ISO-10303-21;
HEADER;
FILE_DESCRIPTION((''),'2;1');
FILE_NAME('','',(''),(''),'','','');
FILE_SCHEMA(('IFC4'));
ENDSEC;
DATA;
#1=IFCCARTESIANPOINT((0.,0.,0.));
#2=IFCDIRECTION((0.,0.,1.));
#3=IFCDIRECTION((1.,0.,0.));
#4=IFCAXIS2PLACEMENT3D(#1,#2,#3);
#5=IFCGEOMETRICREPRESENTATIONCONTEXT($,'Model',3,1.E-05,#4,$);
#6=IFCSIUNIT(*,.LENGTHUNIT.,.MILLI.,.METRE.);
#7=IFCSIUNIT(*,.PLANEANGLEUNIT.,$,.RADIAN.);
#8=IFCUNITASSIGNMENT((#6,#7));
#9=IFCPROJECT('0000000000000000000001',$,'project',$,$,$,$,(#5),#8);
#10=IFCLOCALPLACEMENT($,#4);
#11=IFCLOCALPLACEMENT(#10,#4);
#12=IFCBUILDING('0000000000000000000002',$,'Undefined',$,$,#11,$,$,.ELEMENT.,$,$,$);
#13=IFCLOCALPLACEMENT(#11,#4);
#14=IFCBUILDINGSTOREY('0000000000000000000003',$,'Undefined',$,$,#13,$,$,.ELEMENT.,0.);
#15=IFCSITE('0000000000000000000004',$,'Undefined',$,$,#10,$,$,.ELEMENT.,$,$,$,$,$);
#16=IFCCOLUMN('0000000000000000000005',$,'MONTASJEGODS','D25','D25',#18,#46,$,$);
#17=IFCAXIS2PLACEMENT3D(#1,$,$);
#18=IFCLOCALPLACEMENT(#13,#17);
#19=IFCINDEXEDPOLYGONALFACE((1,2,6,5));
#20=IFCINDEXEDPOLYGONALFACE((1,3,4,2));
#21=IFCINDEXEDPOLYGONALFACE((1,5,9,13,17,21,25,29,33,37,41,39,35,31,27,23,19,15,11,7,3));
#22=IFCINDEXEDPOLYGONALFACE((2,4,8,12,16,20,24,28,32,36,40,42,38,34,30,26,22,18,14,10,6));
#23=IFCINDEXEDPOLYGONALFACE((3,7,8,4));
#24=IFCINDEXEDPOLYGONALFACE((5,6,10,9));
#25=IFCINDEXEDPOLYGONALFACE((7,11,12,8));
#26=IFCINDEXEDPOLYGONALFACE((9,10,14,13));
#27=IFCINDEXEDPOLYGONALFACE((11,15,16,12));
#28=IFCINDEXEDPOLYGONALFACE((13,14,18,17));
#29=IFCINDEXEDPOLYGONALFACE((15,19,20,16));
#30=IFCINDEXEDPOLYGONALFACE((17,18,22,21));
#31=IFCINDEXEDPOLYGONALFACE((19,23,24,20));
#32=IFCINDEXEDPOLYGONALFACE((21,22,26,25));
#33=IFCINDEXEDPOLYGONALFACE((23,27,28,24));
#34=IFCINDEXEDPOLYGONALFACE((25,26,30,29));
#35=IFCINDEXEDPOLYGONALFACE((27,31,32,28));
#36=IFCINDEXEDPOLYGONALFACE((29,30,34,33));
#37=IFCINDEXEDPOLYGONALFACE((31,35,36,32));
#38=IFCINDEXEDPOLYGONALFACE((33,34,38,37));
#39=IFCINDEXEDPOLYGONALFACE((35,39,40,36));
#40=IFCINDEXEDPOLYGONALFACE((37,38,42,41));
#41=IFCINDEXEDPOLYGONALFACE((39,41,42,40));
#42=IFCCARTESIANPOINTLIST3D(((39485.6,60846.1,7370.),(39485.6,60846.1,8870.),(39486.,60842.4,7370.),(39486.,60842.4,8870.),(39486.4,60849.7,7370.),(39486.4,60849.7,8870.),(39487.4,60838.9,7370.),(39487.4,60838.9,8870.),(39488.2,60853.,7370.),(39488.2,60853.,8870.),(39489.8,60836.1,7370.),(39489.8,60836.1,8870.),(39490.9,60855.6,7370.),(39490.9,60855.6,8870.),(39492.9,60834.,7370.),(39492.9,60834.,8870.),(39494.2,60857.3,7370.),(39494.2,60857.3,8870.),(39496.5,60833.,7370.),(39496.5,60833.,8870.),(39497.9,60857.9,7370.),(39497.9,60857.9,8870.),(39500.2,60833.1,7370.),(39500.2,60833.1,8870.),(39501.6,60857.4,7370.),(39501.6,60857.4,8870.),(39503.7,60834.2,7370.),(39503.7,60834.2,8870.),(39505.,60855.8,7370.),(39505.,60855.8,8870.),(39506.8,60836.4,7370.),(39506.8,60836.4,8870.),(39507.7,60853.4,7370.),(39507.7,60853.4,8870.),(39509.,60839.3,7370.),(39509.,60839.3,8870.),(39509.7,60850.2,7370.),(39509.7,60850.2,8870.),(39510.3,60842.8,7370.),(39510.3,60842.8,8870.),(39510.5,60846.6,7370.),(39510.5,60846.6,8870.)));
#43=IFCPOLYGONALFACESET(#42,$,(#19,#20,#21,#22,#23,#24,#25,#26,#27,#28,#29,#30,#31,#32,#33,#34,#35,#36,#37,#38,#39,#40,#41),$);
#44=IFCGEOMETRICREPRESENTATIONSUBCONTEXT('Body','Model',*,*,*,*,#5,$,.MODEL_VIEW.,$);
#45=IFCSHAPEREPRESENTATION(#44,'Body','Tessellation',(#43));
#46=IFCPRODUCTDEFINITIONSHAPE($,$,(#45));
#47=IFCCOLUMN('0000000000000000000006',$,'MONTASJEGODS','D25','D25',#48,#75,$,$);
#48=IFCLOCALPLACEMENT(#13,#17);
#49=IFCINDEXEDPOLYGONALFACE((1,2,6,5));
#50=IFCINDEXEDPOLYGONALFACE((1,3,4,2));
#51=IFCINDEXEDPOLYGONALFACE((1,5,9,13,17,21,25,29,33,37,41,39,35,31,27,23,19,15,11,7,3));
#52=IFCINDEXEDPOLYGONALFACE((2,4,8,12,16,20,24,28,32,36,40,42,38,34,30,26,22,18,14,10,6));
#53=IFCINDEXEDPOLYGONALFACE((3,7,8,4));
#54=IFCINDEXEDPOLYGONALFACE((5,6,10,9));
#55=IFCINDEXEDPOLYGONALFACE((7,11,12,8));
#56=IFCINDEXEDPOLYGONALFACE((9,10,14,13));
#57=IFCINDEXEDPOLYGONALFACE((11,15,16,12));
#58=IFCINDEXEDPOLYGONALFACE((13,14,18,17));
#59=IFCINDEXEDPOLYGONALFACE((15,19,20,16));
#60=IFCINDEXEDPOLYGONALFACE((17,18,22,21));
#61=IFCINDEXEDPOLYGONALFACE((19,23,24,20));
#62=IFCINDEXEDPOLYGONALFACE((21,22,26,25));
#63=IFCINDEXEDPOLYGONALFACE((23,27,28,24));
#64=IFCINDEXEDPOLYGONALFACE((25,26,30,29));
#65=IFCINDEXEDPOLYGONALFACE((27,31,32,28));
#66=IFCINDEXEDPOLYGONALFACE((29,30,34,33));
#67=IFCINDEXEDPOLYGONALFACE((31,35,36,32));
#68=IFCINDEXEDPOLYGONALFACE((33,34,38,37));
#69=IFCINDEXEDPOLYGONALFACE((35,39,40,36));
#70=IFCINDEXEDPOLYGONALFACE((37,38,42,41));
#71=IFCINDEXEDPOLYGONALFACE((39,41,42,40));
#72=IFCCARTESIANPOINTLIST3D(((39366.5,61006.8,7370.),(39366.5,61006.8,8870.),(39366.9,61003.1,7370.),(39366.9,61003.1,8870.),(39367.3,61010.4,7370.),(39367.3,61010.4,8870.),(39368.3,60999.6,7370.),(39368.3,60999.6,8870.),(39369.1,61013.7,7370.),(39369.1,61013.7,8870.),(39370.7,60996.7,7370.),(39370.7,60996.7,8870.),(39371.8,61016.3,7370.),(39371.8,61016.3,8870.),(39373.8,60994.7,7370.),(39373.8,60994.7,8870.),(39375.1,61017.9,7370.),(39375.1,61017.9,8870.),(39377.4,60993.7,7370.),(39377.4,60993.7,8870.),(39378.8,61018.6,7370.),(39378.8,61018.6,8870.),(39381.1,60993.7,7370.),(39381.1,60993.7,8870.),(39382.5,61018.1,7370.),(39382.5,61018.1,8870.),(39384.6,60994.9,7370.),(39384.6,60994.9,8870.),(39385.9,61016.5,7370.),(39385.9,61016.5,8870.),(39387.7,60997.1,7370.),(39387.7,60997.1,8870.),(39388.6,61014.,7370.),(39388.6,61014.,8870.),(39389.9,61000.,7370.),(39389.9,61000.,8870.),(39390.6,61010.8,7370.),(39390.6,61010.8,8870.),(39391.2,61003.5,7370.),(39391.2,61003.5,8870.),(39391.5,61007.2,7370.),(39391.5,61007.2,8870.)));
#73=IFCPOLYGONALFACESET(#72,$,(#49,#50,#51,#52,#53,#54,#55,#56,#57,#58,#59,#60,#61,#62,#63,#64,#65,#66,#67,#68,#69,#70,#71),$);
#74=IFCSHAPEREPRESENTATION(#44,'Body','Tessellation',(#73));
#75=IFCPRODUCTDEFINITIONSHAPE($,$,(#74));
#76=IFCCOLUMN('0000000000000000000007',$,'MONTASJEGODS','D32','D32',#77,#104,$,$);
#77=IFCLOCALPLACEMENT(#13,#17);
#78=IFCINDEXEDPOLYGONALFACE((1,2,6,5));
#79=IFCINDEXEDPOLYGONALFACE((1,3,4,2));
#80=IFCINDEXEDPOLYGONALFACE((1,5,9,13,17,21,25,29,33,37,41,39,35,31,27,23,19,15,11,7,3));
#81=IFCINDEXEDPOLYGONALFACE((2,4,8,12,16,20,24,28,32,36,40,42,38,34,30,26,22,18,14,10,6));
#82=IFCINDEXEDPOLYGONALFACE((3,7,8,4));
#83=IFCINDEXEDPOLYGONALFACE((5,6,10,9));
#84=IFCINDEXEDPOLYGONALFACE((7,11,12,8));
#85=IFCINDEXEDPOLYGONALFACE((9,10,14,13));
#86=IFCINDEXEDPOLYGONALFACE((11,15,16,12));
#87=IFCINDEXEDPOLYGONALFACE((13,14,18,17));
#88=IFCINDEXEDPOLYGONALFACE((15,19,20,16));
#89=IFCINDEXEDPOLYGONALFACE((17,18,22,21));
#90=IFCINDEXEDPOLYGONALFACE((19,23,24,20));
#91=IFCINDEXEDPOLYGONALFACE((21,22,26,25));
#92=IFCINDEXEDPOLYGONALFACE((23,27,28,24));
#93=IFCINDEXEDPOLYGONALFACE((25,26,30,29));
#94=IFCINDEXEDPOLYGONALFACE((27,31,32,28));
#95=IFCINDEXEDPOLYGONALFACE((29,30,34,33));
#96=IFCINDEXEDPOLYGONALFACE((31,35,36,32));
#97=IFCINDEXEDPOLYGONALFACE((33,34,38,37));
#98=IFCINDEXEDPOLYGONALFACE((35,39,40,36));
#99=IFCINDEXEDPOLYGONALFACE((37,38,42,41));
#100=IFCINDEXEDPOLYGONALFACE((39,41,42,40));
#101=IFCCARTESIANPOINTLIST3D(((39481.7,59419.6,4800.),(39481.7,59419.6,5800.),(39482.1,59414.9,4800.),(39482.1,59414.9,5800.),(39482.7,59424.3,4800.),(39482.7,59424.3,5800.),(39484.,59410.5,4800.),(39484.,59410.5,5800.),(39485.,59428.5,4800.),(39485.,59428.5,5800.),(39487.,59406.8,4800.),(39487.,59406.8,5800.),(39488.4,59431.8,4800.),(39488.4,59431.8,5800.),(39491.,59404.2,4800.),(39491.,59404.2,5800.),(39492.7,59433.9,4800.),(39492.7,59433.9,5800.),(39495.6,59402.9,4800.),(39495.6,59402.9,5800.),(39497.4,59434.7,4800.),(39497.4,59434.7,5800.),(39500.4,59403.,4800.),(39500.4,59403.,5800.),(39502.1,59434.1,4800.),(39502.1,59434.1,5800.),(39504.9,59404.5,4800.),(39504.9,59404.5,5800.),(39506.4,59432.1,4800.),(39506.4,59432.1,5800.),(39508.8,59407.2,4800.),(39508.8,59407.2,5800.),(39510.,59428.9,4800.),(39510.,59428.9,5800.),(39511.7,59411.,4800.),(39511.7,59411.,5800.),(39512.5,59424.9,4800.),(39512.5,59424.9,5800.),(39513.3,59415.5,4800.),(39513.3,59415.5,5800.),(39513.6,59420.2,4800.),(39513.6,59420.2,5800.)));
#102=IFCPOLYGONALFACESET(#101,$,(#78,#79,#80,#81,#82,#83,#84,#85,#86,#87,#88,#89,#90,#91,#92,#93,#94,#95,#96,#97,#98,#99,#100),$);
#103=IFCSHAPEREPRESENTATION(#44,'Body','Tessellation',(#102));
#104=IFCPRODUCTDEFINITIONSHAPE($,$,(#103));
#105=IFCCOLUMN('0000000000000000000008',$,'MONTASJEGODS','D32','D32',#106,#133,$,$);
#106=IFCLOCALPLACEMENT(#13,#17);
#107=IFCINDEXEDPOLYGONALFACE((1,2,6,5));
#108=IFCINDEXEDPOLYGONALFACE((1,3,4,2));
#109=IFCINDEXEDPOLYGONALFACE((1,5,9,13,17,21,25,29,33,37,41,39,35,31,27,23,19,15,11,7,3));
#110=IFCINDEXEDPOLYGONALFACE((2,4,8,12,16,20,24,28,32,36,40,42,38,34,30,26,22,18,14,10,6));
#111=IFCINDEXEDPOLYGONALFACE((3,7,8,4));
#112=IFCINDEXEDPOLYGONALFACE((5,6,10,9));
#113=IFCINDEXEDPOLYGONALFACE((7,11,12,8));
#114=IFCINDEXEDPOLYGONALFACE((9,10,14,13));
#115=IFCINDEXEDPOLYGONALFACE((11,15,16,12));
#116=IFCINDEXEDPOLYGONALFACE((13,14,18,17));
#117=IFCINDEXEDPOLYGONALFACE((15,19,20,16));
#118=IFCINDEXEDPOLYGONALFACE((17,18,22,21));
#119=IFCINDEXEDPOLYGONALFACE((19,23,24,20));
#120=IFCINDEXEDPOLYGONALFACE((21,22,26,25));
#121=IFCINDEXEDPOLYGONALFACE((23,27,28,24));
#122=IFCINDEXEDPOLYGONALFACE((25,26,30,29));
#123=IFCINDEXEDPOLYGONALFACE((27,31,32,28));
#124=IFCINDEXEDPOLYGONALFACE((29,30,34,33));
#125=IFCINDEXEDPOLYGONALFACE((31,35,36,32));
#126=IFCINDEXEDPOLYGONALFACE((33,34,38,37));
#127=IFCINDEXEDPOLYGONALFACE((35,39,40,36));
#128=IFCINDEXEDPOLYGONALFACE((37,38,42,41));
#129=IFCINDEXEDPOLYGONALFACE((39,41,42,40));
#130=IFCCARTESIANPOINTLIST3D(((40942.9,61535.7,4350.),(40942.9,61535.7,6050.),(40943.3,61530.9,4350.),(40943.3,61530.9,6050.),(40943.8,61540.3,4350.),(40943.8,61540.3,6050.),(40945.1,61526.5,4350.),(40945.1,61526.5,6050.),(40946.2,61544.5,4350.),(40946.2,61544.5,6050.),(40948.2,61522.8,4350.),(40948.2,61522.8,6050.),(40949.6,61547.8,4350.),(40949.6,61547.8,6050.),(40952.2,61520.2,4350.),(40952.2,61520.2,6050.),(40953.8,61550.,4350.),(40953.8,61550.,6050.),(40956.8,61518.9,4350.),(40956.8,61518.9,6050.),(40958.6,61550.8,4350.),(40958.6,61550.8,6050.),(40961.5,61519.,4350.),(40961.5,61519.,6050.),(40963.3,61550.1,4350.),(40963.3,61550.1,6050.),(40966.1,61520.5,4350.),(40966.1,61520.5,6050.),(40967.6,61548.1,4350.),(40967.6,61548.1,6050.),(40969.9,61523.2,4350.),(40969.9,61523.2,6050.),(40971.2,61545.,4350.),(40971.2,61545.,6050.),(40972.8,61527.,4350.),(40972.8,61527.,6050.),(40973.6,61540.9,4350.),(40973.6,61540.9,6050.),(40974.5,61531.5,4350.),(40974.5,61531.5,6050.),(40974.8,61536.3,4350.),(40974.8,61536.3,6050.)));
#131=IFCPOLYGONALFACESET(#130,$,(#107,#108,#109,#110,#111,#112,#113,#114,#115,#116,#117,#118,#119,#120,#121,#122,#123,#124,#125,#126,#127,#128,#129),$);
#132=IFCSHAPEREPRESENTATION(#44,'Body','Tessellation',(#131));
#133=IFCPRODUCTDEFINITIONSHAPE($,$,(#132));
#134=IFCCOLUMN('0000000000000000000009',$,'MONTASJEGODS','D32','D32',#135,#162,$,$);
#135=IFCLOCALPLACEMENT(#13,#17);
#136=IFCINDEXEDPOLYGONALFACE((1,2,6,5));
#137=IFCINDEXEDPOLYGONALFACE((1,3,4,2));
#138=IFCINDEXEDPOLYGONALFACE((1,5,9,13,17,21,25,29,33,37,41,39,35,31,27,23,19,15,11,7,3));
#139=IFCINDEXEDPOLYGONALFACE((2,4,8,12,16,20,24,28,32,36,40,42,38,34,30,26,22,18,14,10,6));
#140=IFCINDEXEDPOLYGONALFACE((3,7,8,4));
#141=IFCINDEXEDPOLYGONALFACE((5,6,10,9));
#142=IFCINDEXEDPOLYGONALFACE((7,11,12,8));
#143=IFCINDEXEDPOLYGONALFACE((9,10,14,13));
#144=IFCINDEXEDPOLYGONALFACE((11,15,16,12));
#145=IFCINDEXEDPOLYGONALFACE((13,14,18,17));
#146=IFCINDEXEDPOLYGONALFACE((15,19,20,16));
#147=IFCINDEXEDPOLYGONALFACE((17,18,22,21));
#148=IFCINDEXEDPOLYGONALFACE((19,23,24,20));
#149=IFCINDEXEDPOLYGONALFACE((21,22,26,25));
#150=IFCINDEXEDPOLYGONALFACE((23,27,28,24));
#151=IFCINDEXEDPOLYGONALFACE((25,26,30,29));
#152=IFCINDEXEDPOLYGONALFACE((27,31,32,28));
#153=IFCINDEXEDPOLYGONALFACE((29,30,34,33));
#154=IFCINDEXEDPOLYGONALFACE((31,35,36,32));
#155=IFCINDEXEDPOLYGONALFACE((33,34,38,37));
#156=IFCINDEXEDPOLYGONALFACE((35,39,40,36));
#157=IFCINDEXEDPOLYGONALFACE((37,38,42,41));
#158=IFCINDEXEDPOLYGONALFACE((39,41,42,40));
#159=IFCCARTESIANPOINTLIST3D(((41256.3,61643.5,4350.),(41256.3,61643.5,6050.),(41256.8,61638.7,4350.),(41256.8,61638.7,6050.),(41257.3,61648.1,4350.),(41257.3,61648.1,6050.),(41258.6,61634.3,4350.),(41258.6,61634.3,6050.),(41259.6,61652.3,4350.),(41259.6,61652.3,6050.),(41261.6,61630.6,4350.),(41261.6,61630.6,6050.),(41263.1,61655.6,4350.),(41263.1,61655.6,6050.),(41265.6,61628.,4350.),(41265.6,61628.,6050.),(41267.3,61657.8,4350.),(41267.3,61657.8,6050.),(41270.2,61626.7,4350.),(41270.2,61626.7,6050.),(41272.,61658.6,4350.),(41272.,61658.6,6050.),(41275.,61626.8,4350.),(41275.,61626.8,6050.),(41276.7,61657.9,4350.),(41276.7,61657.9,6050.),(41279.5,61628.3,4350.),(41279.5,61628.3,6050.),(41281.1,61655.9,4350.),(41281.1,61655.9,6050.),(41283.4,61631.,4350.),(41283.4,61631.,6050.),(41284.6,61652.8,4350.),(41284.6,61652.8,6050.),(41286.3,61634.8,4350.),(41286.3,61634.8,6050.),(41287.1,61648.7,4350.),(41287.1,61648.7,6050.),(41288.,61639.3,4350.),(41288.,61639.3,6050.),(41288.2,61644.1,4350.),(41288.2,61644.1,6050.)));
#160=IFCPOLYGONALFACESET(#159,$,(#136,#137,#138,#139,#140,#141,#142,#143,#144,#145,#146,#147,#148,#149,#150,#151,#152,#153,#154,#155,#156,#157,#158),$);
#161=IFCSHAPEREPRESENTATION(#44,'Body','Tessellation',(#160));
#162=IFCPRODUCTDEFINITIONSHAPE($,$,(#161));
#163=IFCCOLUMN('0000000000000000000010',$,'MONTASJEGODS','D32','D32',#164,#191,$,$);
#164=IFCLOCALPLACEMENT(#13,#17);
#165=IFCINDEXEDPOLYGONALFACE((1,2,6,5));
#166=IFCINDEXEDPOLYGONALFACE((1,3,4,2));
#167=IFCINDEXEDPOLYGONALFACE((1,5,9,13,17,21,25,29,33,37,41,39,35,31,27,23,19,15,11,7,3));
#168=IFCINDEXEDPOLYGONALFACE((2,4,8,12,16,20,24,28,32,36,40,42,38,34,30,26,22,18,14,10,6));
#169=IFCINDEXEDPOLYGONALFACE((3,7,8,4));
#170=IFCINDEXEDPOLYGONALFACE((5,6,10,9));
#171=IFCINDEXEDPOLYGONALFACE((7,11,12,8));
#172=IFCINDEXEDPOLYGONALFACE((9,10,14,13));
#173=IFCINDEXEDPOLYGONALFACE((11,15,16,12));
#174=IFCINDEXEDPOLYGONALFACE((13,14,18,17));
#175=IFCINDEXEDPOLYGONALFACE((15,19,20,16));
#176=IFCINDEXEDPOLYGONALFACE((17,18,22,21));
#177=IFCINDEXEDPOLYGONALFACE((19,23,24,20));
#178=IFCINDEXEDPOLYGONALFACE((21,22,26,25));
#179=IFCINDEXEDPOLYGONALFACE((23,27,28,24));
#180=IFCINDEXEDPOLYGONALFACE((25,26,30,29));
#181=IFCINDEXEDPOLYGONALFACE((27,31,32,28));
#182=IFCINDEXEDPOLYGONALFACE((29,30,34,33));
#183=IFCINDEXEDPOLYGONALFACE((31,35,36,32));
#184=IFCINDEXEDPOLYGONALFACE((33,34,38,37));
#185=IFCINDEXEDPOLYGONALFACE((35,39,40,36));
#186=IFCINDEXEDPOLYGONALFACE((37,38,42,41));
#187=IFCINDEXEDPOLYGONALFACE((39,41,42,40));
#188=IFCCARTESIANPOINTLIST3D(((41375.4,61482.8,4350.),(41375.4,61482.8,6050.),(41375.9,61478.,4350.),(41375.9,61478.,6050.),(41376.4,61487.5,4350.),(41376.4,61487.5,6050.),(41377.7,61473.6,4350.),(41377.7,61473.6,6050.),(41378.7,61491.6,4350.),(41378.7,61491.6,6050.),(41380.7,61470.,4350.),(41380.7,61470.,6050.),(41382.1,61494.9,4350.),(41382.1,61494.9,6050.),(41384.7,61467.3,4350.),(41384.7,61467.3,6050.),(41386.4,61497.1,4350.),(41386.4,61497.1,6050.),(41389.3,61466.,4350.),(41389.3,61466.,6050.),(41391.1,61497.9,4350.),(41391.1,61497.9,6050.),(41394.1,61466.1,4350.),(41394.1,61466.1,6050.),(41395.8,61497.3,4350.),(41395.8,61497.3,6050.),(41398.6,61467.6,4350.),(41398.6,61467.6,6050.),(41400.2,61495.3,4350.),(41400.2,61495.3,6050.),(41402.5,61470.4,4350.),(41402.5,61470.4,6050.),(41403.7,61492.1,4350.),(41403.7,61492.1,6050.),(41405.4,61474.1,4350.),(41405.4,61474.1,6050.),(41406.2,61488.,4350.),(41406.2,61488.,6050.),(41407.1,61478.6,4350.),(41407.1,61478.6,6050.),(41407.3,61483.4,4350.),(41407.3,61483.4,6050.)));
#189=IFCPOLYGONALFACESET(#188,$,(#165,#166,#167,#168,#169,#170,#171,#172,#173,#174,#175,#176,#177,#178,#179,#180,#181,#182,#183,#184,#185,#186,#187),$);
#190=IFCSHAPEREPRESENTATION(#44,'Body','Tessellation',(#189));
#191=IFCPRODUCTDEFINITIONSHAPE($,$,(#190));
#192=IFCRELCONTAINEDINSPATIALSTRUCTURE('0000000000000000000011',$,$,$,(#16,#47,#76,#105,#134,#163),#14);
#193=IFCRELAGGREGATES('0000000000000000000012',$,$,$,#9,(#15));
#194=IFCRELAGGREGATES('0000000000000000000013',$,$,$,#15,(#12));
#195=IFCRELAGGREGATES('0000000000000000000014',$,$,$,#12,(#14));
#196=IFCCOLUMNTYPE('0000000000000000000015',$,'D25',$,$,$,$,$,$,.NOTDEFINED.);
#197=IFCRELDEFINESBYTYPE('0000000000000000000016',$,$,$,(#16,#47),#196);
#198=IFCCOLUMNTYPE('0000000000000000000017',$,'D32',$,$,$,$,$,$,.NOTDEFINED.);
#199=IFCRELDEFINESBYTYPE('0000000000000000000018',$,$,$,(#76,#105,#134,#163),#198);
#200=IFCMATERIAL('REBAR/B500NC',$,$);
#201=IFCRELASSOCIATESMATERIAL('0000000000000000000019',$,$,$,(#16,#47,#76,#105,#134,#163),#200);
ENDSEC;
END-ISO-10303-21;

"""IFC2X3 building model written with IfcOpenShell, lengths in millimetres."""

from ifc_helpers import new_model, si_unit, frame, origin_with_axes, origin_2d_with_axis, place, context, subcontext, project, spatial, circle, extrude, material, type_object, element, save


model = new_model("IFC2X3")

# Units and contexts
model_context = context("Model", 3, precision=1e-05, world=origin_with_axes())
body_context = subcontext(model_context, "Body", "Model", "MODEL_VIEW")
ifc_project = project(units=[si_unit("LENGTHUNIT", "METRE", prefix="MILLI"), si_unit("PLANEANGLEUNIT", "RADIAN")], contexts=[model_context])

# Site, building, storey
site_placement = place(None, origin_with_axes())
site = spatial("IfcSite", under=ifc_project, at=site_placement, Name="Undefined", CompositionType="ELEMENT")
building_placement = place(site_placement, origin_with_axes())
building = spatial("IfcBuilding", under=site, at=building_placement, Name="Undefined", CompositionType="ELEMENT")
storey_placement = place(building_placement, origin_with_axes())
storey = spatial("IfcBuildingStorey", under=building, at=storey_placement, Name="Undefined", CompositionType="ELEMENT", Elevation=0.0)

# Columns
ifc_material_1 = material(Name="REBAR/B500NC")
column_type_1 = type_object("IfcColumnType", Name="D25", PredefinedType="NOTDEFINED")
for number, where, z_axis, x_axis, name in (
    (1, (39498.1, 60845.4, 7370.0), (0.0, 0.0, 1.0), (-0.892819, -0.450415, 0.0), "MONTASJEGODS"),
    (2, (39379.0, 61006.1, 7370.0), (0.0, 0.0, 1.0), (-0.892819, -0.450415, 0.0), "MONTASJEGODS"),
):
    element("IfcColumn", number, at=place(storey_placement, frame(where, z_axis=z_axis, x_axis=x_axis)), inside=storey, type_object=column_type_1, material=ifc_material_1, Name=name, Description="D25", ObjectType="D25", context=body_context, shape_type="SweptSolid", body=[
        extrude(circle(Radius=12.5, at=origin_2d_with_axis()), frame((0.0, 0.0, 1500.0), z_axis=(0.0, 0.0, -1.0), x_axis=(0.0, 1.0, 0.0)), (0.0, 0.0, 1.0), 1500.0),
    ])
column_type_2 = type_object("IfcColumnType", Name="D32", PredefinedType="NOTDEFINED")
column_placement = place(storey_placement, frame((39497.7, 59418.7, 4800.0), z_axis=(0.0, 0.0, 1.0), x_axis=(-0.892819, -0.450415, 0.0)))
element("IfcColumn", 3, at=column_placement, inside=storey, type_object=column_type_2, material=ifc_material_1, Name="MONTASJEGODS", Description="D32", ObjectType="D32", context=body_context, shape_type="SweptSolid", body=[
    extrude(circle(Radius=16.0, at=origin_2d_with_axis()), frame((0.0, 0.0, 1000.0), z_axis=(0.0, 0.0, -1.0), x_axis=(0.0, 1.0, 0.0)), (0.0, 0.0, 1.0), 1000.0),
])
for number, where, z_axis, x_axis, name in (
    (4, (40958.8, 61534.8, 4350.0), (0.0, 0.0, 1.0), (-0.892819, -0.450415, 0.0), "MONTASJEGODS"),
    (5, (41272.3, 61642.6, 4350.0), (0.0, 0.0, 1.0), (-0.892819, -0.450415, 0.0), "MONTASJEGODS"),
    (6, (41391.4, 61481.9, 4350.0), (0.0, 0.0, 1.0), (-0.892819, -0.450415, 0.0), "MONTASJEGODS"),
):
    element("IfcColumn", number, at=place(storey_placement, frame(where, z_axis=z_axis, x_axis=x_axis)), inside=storey, type_object=column_type_2, material=ifc_material_1, Name=name, Description="D32", ObjectType="D32", context=body_context, shape_type="SweptSolid", body=[
        extrude(circle(Radius=16.0, at=origin_2d_with_axis()), frame((0.0, 0.0, 1700.0), z_axis=(0.0, 0.0, -1.0), x_axis=(0.0, 1.0, 0.0)), (0.0, 0.0, 1.0), 1700.0),
    ])

save(model, "model.ifc")
